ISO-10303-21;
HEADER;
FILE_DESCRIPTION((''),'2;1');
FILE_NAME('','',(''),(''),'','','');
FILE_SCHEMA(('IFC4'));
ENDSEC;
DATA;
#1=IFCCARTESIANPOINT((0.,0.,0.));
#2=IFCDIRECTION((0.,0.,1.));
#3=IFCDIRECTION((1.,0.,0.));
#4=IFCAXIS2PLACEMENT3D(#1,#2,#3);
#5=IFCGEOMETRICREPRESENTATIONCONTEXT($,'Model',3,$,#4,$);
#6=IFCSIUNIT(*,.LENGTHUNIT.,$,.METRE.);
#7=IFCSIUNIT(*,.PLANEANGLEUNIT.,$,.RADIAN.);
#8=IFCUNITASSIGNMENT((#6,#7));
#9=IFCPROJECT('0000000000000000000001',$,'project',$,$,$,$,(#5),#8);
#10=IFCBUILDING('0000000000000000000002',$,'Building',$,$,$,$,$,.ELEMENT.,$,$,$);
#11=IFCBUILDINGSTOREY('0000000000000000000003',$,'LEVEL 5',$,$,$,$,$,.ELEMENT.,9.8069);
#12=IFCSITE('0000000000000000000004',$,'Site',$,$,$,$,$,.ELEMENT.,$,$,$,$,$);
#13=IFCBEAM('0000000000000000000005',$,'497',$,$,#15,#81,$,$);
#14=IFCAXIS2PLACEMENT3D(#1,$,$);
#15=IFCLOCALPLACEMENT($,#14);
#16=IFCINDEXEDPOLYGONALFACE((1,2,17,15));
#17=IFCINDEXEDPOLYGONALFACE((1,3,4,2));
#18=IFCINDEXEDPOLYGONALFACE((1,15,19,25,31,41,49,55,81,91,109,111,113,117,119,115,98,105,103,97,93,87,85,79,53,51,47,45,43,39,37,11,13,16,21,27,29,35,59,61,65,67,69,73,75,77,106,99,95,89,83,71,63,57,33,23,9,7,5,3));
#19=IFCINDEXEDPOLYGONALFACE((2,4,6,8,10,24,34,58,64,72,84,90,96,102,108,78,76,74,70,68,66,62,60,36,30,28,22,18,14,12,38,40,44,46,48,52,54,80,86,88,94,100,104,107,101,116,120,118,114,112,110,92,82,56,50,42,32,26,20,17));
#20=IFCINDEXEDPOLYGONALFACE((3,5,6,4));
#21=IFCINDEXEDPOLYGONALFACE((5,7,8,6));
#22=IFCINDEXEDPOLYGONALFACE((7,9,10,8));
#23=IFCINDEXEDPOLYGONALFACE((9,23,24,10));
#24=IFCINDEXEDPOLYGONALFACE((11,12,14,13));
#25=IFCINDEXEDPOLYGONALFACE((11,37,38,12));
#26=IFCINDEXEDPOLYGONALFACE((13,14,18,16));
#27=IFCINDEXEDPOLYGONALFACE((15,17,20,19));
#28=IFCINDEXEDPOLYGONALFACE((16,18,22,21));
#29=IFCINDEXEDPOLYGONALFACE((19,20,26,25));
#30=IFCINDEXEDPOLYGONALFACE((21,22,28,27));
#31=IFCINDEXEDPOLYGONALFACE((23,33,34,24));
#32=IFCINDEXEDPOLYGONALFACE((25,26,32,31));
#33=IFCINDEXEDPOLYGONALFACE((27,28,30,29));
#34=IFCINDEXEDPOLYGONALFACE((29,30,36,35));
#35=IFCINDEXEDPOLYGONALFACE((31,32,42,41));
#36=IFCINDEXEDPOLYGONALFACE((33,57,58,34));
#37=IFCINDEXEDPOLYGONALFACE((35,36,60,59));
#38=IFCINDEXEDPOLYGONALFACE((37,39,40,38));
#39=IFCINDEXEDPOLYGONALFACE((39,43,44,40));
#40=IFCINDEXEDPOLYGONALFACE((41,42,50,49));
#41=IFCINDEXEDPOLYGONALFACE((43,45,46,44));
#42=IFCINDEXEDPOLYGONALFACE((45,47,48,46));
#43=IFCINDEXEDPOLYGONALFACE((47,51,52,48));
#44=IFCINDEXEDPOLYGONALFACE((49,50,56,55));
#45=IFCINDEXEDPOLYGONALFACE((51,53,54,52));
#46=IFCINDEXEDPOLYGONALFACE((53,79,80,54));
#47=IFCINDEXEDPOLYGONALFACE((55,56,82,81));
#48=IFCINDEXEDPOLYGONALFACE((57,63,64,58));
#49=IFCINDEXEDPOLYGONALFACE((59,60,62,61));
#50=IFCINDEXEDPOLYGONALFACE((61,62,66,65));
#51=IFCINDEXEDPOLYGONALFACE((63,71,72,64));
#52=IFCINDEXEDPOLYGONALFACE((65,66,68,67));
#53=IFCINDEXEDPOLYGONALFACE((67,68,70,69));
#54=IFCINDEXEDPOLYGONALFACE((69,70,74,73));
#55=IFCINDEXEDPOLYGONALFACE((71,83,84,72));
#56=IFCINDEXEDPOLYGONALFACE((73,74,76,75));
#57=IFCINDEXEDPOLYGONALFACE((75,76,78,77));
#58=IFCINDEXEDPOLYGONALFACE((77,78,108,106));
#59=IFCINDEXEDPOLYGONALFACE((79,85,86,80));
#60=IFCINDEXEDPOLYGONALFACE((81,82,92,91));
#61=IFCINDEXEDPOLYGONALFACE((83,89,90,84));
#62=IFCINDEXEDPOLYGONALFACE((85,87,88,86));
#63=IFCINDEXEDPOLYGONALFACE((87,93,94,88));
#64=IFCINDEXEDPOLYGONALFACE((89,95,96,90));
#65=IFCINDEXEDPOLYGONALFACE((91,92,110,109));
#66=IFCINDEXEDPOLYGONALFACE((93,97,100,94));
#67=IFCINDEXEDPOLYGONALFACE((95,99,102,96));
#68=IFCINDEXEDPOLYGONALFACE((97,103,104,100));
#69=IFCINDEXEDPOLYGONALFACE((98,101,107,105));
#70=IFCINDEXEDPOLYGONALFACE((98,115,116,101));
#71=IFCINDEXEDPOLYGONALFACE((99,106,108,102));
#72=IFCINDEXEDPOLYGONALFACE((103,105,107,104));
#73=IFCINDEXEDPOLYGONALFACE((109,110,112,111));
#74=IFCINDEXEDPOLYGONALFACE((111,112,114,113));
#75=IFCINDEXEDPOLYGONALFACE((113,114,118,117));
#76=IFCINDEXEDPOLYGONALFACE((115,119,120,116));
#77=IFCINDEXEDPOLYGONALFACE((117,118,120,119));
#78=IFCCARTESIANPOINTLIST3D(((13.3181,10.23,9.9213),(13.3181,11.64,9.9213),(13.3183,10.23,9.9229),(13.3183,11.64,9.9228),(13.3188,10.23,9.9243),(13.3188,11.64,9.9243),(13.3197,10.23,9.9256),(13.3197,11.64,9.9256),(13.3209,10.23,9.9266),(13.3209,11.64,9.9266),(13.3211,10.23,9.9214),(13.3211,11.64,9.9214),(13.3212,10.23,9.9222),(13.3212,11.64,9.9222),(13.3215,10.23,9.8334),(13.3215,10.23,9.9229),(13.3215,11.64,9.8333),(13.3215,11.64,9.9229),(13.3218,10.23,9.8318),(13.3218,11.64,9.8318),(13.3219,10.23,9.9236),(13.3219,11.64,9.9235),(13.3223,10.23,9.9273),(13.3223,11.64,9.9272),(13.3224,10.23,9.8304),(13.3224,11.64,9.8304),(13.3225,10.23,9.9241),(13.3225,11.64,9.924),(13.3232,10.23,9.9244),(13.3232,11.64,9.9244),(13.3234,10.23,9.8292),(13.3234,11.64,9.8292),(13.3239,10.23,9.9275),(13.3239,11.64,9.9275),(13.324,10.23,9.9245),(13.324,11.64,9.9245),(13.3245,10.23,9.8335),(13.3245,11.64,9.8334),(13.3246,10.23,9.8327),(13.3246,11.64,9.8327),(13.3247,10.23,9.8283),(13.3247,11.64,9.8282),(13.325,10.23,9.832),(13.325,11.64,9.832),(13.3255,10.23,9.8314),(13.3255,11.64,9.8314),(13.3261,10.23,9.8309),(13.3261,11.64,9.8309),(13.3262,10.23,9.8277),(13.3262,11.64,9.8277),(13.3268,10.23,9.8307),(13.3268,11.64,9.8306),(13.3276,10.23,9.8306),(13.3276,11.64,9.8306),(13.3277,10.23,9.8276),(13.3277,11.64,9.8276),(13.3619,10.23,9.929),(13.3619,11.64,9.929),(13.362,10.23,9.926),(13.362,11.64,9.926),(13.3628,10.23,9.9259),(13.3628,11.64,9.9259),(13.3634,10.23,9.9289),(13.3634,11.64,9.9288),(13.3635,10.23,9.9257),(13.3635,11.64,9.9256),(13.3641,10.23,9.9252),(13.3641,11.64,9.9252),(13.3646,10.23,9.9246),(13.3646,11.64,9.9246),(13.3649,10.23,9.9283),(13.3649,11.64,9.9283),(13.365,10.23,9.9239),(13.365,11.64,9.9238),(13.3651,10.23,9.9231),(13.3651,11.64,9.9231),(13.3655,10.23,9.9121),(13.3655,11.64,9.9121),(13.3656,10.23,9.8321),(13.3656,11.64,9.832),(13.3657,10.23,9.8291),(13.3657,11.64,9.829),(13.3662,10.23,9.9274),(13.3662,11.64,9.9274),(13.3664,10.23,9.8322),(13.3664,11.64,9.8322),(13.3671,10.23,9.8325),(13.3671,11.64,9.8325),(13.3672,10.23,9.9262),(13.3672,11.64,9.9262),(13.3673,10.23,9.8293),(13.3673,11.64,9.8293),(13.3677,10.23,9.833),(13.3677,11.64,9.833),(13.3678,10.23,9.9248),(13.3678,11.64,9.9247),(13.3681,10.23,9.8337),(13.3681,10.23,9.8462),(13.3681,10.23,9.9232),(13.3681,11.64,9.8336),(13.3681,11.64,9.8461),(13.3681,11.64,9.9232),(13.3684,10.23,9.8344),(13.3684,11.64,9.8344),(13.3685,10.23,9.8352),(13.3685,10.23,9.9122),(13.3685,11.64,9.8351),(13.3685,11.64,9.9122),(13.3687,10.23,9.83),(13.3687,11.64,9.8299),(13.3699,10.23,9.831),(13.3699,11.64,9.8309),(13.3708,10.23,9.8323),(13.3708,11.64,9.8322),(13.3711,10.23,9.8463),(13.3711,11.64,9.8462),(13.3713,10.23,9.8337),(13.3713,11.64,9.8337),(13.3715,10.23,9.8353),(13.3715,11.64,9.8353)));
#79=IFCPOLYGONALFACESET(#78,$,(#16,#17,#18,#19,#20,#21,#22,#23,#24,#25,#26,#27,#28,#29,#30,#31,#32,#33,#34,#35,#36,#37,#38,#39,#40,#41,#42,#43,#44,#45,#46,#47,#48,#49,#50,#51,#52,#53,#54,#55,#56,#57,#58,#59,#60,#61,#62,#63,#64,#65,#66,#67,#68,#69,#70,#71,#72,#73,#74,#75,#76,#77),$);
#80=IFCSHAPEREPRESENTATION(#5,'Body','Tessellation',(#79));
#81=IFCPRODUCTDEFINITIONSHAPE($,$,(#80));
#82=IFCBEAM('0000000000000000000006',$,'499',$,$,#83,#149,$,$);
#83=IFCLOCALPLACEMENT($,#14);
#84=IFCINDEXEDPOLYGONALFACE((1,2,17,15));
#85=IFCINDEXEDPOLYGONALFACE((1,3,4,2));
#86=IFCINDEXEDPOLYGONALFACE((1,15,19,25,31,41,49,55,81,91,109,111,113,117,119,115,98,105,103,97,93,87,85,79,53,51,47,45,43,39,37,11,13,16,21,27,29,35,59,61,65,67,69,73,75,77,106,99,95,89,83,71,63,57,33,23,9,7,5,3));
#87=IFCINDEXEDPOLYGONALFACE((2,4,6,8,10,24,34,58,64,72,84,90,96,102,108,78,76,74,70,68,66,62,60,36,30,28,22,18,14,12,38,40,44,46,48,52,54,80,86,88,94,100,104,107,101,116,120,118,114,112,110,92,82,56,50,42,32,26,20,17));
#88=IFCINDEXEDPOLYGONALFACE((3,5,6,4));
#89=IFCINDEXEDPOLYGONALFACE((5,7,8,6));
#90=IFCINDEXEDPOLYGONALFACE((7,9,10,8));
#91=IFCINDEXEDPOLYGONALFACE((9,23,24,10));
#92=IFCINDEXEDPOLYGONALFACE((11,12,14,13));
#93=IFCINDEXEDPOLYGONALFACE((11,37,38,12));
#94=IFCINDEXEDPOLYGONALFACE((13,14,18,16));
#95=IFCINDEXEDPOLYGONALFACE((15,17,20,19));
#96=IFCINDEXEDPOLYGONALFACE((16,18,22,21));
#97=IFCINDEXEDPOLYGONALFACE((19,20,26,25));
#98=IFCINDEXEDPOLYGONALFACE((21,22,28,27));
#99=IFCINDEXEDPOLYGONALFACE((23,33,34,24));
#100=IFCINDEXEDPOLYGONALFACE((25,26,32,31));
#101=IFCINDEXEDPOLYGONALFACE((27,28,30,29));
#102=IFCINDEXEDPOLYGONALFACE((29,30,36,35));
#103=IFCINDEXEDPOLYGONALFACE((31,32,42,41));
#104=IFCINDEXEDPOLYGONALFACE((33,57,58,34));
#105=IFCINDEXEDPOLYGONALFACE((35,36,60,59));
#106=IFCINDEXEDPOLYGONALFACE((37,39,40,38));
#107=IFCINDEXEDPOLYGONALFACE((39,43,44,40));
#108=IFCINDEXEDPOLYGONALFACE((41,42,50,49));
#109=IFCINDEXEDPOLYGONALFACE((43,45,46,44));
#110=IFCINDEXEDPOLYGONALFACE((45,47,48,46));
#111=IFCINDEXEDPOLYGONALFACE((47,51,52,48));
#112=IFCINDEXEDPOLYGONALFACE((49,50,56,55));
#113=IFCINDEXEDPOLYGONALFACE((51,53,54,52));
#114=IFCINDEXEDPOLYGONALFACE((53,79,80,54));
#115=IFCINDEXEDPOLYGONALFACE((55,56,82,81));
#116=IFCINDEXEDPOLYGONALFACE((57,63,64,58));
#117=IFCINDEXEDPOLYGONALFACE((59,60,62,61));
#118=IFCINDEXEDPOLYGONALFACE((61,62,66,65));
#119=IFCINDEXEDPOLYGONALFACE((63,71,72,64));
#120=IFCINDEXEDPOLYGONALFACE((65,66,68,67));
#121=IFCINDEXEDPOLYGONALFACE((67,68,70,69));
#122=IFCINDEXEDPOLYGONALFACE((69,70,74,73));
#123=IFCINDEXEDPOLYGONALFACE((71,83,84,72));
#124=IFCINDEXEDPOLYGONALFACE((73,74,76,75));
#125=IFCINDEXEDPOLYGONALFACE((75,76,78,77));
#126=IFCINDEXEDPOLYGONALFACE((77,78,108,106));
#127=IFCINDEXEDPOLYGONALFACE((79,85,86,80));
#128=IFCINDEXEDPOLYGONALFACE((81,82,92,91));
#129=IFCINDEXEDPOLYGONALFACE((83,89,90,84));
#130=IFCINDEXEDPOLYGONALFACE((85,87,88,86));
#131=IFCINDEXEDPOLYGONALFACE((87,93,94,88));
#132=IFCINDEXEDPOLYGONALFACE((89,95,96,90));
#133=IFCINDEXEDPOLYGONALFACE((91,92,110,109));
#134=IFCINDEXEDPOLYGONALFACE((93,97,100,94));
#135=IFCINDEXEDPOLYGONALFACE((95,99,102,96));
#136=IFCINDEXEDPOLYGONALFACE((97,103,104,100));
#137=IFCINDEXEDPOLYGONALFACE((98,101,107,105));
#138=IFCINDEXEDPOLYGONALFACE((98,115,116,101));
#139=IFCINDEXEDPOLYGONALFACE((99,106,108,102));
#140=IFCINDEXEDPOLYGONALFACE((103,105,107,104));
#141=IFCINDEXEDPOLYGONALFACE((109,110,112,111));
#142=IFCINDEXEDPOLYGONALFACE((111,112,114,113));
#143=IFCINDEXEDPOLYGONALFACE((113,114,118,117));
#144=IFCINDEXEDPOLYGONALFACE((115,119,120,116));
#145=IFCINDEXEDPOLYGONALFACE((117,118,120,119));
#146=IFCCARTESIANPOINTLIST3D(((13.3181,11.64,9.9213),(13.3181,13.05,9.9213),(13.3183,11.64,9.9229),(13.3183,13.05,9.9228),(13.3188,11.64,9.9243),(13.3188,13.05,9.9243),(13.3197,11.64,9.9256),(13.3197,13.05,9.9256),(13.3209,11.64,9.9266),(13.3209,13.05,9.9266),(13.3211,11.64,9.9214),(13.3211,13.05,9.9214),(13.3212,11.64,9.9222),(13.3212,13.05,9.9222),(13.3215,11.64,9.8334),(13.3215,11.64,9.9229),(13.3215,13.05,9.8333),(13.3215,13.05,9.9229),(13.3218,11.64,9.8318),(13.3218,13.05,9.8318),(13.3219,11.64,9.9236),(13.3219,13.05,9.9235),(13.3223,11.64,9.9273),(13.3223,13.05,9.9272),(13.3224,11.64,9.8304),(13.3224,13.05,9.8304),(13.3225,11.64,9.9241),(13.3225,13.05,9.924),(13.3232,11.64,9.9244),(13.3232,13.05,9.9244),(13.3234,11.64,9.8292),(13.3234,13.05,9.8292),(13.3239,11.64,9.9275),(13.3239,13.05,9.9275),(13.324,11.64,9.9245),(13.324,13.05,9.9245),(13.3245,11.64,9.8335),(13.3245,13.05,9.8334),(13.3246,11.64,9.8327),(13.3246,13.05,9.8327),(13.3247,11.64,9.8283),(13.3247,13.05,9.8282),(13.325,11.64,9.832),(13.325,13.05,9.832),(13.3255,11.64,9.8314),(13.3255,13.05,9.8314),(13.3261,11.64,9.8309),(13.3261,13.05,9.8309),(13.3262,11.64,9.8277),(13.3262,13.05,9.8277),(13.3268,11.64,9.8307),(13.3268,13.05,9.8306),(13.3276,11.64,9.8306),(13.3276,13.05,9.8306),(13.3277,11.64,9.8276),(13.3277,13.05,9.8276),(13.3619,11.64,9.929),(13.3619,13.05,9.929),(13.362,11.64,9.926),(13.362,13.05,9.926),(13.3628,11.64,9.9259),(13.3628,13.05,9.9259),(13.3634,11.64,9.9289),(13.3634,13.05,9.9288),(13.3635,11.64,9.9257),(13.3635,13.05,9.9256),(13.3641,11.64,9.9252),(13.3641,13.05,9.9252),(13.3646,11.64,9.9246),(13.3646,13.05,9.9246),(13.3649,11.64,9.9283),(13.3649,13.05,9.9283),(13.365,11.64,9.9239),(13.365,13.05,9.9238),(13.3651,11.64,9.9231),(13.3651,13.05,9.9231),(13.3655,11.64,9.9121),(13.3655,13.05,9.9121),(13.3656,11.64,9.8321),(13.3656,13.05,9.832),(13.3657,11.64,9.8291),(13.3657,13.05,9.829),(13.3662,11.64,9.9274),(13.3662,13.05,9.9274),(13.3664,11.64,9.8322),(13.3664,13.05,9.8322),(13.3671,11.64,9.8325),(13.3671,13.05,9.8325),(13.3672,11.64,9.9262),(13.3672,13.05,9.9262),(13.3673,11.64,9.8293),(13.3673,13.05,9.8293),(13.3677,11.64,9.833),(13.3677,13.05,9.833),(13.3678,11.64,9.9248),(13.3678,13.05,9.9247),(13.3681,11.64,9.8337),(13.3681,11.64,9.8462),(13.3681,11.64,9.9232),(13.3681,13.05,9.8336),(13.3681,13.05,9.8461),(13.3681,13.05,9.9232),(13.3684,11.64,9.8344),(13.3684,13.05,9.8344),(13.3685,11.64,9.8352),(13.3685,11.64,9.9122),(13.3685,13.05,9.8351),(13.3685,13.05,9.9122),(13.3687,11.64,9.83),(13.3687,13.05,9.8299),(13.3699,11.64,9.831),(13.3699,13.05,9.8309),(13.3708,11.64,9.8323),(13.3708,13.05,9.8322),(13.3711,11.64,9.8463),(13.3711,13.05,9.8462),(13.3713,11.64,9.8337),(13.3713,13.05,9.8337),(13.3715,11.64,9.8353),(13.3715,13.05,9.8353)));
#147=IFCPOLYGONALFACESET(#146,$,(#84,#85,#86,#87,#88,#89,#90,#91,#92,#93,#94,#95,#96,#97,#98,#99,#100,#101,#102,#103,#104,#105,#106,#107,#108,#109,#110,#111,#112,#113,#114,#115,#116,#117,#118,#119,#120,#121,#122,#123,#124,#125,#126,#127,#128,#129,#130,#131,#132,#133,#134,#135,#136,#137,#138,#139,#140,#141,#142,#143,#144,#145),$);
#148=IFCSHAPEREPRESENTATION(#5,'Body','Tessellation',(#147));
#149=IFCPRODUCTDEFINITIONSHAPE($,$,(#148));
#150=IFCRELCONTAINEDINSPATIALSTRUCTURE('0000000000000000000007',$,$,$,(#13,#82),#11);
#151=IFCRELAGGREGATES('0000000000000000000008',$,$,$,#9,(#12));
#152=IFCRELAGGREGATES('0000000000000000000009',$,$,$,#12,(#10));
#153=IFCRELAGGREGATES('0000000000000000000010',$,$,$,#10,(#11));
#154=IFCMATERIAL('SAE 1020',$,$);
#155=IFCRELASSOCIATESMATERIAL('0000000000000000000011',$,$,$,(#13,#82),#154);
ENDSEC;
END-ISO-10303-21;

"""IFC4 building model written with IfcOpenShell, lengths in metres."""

from ifc_helpers import new_model, si_unit, frame, origin_with_axes, origin_2d_with_axis, place, context, project, spatial, c_section, extrude, material, material_profile, profile_set, profile_usage, element, save


model = new_model("IFC4")

# Units and contexts
model_context = context("Model", 3, world=origin_with_axes())
ifc_project = project(units=[si_unit("LENGTHUNIT", "METRE"), si_unit("PLANEANGLEUNIT", "RADIAN")], contexts=[model_context])

# Site, building, storey
site = spatial("IfcSite", under=ifc_project, Name="Site", CompositionType="ELEMENT")
building = spatial("IfcBuilding", under=site, Name="Building", CompositionType="ELEMENT")
storey = spatial("IfcBuildingStorey", under=building, Name="LEVEL 5", CompositionType="ELEMENT", Elevation=9.8069)

# Beams
ifc_material = material(Name="SAE 1020")
ifc_material_profile_1 = material_profile(ifc_material, c_section(Depth=0.1, Width=0.05, WallThickness=0.003, Girth=0.017, InternalFilletRadius=0.003, at=origin_2d_with_axis()))
ifc_profile_set_1 = profile_set([ifc_material_profile_1])
ifc_profile_usage_1 = profile_usage(ifc_profile_set_1, cardinal=10)
beam_1_placement = place(None, frame((13.3448, 10.23, 9.8783), z_axis=(0.0, 1.0, -0.00003), x_axis=(0.999256, 0.000001, 0.038562)))
element("IfcBeam", 1, at=beam_1_placement, inside=storey, material=ifc_profile_usage_1, Name="497", context=model_context, shape_type="SweptSolid", body=[
    extrude(c_section(Depth=0.1, Width=0.05, WallThickness=0.003, Girth=0.017, InternalFilletRadius=0.003, at=origin_2d_with_axis()), origin_with_axes(), (0.0, 0.0, 1.0), 1.41),
])
ifc_material_profile_2 = material_profile(ifc_material, c_section(Depth=0.1, Width=0.05, WallThickness=0.003, Girth=0.017, InternalFilletRadius=0.003, at=origin_2d_with_axis()))
ifc_profile_set_2 = profile_set([ifc_material_profile_2])
ifc_profile_usage_2 = profile_usage(ifc_profile_set_2, cardinal=10)
beam_2_placement = place(None, frame((13.3448, 11.64, 9.8783), z_axis=(0.0, 1.0, -0.00003), x_axis=(0.999256, 0.000001, 0.038562)))
element("IfcBeam", 2, at=beam_2_placement, inside=storey, material=ifc_profile_usage_2, Name="499", context=model_context, shape_type="SweptSolid", body=[
    extrude(c_section(Depth=0.1, Width=0.05, WallThickness=0.003, Girth=0.017, InternalFilletRadius=0.003, at=origin_2d_with_axis()), origin_with_axes(), (0.0, 0.0, 1.0), 1.41),
])

save(model, "model.ifc")
